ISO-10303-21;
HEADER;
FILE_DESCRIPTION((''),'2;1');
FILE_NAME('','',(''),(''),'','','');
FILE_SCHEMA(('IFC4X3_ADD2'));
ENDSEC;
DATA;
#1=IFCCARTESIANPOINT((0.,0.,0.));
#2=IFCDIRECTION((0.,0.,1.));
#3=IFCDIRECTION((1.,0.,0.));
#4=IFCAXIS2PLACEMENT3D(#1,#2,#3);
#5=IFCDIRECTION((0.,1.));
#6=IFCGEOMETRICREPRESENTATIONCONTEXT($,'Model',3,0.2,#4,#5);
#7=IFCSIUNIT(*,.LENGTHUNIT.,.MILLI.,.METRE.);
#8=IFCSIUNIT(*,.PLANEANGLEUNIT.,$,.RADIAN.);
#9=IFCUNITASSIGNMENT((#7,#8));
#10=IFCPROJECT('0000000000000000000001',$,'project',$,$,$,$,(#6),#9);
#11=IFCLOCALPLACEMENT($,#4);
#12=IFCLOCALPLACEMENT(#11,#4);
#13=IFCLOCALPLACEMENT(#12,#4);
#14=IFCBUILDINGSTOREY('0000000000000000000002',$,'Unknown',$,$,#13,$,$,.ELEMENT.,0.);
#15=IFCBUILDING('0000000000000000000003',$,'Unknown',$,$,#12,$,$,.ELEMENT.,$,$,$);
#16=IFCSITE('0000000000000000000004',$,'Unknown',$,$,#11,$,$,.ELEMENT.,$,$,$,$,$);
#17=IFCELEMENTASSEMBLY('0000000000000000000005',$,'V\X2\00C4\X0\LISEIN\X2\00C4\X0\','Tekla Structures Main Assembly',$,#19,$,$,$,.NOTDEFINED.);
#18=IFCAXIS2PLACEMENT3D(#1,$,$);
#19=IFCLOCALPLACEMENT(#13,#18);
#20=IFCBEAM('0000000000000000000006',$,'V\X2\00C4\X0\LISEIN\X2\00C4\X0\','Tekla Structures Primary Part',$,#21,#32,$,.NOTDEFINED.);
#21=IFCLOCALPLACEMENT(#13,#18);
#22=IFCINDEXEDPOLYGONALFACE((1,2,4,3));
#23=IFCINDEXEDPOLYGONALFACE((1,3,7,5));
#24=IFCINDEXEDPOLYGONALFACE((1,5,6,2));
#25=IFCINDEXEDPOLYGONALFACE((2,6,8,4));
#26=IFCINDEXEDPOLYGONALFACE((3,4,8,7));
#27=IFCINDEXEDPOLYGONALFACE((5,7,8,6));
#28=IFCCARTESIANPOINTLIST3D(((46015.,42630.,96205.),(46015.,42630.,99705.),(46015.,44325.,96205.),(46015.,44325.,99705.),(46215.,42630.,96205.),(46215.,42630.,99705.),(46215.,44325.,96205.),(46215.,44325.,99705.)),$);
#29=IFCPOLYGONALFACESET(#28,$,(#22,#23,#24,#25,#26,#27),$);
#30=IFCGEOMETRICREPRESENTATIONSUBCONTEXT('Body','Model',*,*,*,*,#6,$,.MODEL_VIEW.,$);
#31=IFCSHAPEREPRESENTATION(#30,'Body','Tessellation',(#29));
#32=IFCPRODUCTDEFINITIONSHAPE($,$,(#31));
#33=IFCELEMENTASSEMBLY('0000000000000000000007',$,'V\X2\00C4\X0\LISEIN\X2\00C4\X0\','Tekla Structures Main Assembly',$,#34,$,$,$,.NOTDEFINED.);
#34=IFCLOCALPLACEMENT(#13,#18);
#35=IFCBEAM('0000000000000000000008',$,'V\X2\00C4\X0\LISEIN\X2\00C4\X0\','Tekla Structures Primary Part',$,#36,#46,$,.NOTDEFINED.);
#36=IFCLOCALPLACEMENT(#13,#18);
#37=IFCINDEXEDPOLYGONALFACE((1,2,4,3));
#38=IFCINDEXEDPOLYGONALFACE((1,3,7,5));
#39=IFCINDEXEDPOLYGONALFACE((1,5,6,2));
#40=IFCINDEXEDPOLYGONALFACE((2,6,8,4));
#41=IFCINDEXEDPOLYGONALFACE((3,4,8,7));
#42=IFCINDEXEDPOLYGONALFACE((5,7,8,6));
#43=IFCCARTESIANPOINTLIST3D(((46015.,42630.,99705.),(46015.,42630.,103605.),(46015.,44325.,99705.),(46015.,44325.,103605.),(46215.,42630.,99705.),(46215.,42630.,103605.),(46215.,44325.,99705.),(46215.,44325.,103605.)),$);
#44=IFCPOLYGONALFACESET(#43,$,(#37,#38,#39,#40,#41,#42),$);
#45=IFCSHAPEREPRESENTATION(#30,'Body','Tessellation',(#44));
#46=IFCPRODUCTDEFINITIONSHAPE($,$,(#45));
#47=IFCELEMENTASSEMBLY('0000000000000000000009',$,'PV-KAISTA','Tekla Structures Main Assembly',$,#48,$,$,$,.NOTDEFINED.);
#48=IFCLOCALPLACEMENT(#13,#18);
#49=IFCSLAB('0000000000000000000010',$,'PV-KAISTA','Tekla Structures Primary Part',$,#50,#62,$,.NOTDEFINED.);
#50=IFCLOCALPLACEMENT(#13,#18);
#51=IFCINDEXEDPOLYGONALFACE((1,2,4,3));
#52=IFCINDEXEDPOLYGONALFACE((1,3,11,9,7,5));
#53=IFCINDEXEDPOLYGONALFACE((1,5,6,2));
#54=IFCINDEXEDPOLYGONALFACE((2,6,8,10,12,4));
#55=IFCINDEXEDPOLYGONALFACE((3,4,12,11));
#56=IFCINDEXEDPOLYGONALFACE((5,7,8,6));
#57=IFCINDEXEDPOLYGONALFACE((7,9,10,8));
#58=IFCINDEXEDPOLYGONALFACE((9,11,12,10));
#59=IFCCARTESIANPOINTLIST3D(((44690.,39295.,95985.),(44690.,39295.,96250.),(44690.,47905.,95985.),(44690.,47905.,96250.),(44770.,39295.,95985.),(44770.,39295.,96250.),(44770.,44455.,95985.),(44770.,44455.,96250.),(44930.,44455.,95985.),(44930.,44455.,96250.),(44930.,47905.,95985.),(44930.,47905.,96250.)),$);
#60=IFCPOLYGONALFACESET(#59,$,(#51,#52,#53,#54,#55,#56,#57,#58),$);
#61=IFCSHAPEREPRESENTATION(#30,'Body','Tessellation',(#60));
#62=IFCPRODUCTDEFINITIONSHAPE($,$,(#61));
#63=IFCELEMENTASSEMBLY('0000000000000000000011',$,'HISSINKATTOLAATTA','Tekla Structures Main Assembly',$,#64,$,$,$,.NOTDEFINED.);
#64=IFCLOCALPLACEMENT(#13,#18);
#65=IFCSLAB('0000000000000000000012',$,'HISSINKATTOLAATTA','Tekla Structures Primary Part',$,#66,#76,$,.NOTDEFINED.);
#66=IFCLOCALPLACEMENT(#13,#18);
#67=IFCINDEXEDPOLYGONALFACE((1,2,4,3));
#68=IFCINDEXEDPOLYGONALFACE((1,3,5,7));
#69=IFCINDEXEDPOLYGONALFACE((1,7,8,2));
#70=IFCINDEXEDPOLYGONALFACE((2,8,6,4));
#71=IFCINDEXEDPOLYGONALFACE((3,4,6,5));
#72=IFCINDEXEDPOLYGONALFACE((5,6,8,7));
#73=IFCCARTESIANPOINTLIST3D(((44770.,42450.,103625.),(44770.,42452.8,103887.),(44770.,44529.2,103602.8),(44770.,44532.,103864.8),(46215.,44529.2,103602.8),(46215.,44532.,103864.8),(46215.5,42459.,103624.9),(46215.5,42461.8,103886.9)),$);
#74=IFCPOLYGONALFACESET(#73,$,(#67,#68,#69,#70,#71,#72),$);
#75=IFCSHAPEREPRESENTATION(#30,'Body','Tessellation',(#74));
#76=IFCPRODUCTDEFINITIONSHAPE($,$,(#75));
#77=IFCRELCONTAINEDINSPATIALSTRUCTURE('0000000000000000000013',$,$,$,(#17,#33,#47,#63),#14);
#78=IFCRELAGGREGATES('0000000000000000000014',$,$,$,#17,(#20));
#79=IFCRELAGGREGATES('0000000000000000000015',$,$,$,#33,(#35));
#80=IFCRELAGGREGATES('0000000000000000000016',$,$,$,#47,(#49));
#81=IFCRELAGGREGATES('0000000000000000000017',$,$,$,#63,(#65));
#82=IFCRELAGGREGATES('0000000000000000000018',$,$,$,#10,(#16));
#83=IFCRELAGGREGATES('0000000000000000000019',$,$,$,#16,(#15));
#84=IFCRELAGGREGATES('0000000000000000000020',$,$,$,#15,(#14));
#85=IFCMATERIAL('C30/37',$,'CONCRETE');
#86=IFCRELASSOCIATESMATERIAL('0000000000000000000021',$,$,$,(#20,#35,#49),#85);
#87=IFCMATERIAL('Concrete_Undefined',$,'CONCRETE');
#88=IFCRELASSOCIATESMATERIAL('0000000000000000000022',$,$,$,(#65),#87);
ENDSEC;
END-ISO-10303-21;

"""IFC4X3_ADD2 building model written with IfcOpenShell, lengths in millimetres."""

from ifc_helpers import new_model, si_unit, direction, frame, origin_with_axes, place, context, subcontext, project, spatial, line, indexed_curve, outline, extrude, material, element, aggregate, save


model = new_model("IFC4X3_ADD2")

# Units and contexts
model_context = context("Model", 3, precision=0.2, world=origin_with_axes(), true_north=direction((0.0, 1.0)))
body_context = subcontext(model_context, "Body", "Model", "MODEL_VIEW")
ifc_project = project(units=[si_unit("LENGTHUNIT", "METRE", prefix="MILLI"), si_unit("PLANEANGLEUNIT", "RADIAN")], contexts=[model_context])

# Site, building, storey
site_placement = place(None, origin_with_axes())
site = spatial("IfcSite", under=ifc_project, at=site_placement, Name="Unknown", CompositionType="ELEMENT")
building_placement = place(site_placement, origin_with_axes())
building = spatial("IfcBuilding", under=site, at=building_placement, Name="Unknown", CompositionType="ELEMENT")
storey_placement = place(building_placement, origin_with_axes())
storey = spatial("IfcBuildingStorey", under=building, at=storey_placement, Name="Unknown", CompositionType="ELEMENT", Elevation=0.0)

# Shared definitions
ifc_material_1 = material(Name="Concrete_Undefined", Category="CONCRETE")

# Element assemblies, beams
ifc_material_2 = material(Name="C30/37", Category="CONCRETE")
assembly_1_placement = place(storey_placement, frame((46115.0, 42630.0, 97955.0), z_axis=(1.0, 0.0, 0.0), x_axis=(0.0, 1.0, 0.0)))
assembly_1 = element("IfcElementAssembly", 1, at=assembly_1_placement, inside=storey, Name="VÄLISEINÄ", Description="Tekla Structures Main Assembly", PredefinedType="NOTDEFINED")
beam_1_placement = place(assembly_1_placement, origin_with_axes())
beam_1 = element("IfcBeam", 2, at=beam_1_placement, material=ifc_material_2, Name="VÄLISEINÄ", Description="Tekla Structures Primary Part", PredefinedType="NOTDEFINED", context=body_context, shape_type="SolidModel", body=[
    extrude(outline(indexed_curve([(-100.0, -1750.0), (100.0, -1750.0), (100.0, 1750.0), (-100.0, 1750.0)], segments=[line(1, 2, 3, 4, 1)])), frame((0.0, 0.0, 0.0), z_axis=(-1.0, 0.0, 0.0), x_axis=(0.0, 0.0, 1.0)), (0.0, 0.0, -1.0), 1695.0),
])
aggregate(assembly_1, [beam_1])
assembly_2_placement = place(storey_placement, frame((46115.0, 42630.0, 101655.0), z_axis=(1.0, 0.0, 0.0), x_axis=(0.0, 1.0, 0.0)))
assembly_2 = element("IfcElementAssembly", 3, at=assembly_2_placement, inside=storey, Name="VÄLISEINÄ", Description="Tekla Structures Main Assembly", PredefinedType="NOTDEFINED")
beam_2_placement = place(assembly_2_placement, origin_with_axes())
beam_2 = element("IfcBeam", 4, at=beam_2_placement, material=ifc_material_2, Name="VÄLISEINÄ", Description="Tekla Structures Primary Part", PredefinedType="NOTDEFINED", context=body_context, shape_type="SolidModel", body=[
    extrude(outline(indexed_curve([(-100.0, -1950.0), (100.0, -1950.0), (100.0, 1950.0), (-100.0, 1950.0)], segments=[line(1, 2, 3, 4, 1)])), frame((0.0, 0.0, 0.0), z_axis=(-1.0, 0.0, 0.0), x_axis=(0.0, 0.0, 1.0)), (0.0, 0.0, -1.0), 1695.0),
])
aggregate(assembly_2, [beam_2])

# Element assemblies, slabs
assembly_3_placement = place(storey_placement, frame((44930.0, 47905.0, 96117.5), z_axis=(0.0, 0.0, 1.0), x_axis=(-1.0, 0.0, 0.0)))
assembly_3 = element("IfcElementAssembly", 5, at=assembly_3_placement, inside=storey, Name="PV-KAISTA", Description="Tekla Structures Main Assembly", PredefinedType="NOTDEFINED")
slab_1_placement = place(assembly_3_placement, origin_with_axes())
slab_1 = element("IfcSlab", 6, at=slab_1_placement, material=ifc_material_2, Name="PV-KAISTA", Description="Tekla Structures Primary Part", PredefinedType="NOTDEFINED", context=body_context, shape_type="SolidModel", body=[
    extrude(outline(indexed_curve([(0.0, 0.0), (240.0, 0.0), (240.0, 8610.0), (160.0, 8610.0), (160.0, 3450.0), (0.0, 3450.0)], segments=[line(1, 2, 3, 4, 5, 6, 1)])), frame((0.0, 0.0, 132.5), z_axis=(0.0, 0.0, 1.0), x_axis=(1.0, 0.0, 0.0)), (0.0, 0.0, -1.0), 265.0),
])
aggregate(assembly_3, [slab_1])
assembly_4_placement = place(storey_placement, frame((44770.0, 44530.6, 103733.8), z_axis=(0.0, 0.010666, 0.999943), x_axis=(0.000002, -0.999943, 0.010666)))
assembly_4 = element("IfcElementAssembly", 7, at=assembly_4_placement, inside=storey, Name="HISSINKATTOLAATTA", Description="Tekla Structures Main Assembly", PredefinedType="NOTDEFINED")
slab_2_placement = place(assembly_4_placement, origin_with_axes())
slab_2 = element("IfcSlab", 8, at=slab_2_placement, material=ifc_material_1, Name="HISSINKATTOLAATTA", Description="Tekla Structures Primary Part", PredefinedType="NOTDEFINED", context=body_context, shape_type="SolidModel", body=[
    extrude(outline(indexed_curve([(0.0, 0.0), (2079.4, 0.0), (2070.4, 1445.5), (0.0, 1445.0)], segments=[line(1, 2, 3, 4, 1)])), frame((0.0, 0.0, 131.0), z_axis=(0.0, 0.0, 1.0), x_axis=(1.0, 0.0, 0.0)), (0.0, 0.0, -1.0), 262.0),
])
aggregate(assembly_4, [slab_2])

save(model, "model.ifc")
